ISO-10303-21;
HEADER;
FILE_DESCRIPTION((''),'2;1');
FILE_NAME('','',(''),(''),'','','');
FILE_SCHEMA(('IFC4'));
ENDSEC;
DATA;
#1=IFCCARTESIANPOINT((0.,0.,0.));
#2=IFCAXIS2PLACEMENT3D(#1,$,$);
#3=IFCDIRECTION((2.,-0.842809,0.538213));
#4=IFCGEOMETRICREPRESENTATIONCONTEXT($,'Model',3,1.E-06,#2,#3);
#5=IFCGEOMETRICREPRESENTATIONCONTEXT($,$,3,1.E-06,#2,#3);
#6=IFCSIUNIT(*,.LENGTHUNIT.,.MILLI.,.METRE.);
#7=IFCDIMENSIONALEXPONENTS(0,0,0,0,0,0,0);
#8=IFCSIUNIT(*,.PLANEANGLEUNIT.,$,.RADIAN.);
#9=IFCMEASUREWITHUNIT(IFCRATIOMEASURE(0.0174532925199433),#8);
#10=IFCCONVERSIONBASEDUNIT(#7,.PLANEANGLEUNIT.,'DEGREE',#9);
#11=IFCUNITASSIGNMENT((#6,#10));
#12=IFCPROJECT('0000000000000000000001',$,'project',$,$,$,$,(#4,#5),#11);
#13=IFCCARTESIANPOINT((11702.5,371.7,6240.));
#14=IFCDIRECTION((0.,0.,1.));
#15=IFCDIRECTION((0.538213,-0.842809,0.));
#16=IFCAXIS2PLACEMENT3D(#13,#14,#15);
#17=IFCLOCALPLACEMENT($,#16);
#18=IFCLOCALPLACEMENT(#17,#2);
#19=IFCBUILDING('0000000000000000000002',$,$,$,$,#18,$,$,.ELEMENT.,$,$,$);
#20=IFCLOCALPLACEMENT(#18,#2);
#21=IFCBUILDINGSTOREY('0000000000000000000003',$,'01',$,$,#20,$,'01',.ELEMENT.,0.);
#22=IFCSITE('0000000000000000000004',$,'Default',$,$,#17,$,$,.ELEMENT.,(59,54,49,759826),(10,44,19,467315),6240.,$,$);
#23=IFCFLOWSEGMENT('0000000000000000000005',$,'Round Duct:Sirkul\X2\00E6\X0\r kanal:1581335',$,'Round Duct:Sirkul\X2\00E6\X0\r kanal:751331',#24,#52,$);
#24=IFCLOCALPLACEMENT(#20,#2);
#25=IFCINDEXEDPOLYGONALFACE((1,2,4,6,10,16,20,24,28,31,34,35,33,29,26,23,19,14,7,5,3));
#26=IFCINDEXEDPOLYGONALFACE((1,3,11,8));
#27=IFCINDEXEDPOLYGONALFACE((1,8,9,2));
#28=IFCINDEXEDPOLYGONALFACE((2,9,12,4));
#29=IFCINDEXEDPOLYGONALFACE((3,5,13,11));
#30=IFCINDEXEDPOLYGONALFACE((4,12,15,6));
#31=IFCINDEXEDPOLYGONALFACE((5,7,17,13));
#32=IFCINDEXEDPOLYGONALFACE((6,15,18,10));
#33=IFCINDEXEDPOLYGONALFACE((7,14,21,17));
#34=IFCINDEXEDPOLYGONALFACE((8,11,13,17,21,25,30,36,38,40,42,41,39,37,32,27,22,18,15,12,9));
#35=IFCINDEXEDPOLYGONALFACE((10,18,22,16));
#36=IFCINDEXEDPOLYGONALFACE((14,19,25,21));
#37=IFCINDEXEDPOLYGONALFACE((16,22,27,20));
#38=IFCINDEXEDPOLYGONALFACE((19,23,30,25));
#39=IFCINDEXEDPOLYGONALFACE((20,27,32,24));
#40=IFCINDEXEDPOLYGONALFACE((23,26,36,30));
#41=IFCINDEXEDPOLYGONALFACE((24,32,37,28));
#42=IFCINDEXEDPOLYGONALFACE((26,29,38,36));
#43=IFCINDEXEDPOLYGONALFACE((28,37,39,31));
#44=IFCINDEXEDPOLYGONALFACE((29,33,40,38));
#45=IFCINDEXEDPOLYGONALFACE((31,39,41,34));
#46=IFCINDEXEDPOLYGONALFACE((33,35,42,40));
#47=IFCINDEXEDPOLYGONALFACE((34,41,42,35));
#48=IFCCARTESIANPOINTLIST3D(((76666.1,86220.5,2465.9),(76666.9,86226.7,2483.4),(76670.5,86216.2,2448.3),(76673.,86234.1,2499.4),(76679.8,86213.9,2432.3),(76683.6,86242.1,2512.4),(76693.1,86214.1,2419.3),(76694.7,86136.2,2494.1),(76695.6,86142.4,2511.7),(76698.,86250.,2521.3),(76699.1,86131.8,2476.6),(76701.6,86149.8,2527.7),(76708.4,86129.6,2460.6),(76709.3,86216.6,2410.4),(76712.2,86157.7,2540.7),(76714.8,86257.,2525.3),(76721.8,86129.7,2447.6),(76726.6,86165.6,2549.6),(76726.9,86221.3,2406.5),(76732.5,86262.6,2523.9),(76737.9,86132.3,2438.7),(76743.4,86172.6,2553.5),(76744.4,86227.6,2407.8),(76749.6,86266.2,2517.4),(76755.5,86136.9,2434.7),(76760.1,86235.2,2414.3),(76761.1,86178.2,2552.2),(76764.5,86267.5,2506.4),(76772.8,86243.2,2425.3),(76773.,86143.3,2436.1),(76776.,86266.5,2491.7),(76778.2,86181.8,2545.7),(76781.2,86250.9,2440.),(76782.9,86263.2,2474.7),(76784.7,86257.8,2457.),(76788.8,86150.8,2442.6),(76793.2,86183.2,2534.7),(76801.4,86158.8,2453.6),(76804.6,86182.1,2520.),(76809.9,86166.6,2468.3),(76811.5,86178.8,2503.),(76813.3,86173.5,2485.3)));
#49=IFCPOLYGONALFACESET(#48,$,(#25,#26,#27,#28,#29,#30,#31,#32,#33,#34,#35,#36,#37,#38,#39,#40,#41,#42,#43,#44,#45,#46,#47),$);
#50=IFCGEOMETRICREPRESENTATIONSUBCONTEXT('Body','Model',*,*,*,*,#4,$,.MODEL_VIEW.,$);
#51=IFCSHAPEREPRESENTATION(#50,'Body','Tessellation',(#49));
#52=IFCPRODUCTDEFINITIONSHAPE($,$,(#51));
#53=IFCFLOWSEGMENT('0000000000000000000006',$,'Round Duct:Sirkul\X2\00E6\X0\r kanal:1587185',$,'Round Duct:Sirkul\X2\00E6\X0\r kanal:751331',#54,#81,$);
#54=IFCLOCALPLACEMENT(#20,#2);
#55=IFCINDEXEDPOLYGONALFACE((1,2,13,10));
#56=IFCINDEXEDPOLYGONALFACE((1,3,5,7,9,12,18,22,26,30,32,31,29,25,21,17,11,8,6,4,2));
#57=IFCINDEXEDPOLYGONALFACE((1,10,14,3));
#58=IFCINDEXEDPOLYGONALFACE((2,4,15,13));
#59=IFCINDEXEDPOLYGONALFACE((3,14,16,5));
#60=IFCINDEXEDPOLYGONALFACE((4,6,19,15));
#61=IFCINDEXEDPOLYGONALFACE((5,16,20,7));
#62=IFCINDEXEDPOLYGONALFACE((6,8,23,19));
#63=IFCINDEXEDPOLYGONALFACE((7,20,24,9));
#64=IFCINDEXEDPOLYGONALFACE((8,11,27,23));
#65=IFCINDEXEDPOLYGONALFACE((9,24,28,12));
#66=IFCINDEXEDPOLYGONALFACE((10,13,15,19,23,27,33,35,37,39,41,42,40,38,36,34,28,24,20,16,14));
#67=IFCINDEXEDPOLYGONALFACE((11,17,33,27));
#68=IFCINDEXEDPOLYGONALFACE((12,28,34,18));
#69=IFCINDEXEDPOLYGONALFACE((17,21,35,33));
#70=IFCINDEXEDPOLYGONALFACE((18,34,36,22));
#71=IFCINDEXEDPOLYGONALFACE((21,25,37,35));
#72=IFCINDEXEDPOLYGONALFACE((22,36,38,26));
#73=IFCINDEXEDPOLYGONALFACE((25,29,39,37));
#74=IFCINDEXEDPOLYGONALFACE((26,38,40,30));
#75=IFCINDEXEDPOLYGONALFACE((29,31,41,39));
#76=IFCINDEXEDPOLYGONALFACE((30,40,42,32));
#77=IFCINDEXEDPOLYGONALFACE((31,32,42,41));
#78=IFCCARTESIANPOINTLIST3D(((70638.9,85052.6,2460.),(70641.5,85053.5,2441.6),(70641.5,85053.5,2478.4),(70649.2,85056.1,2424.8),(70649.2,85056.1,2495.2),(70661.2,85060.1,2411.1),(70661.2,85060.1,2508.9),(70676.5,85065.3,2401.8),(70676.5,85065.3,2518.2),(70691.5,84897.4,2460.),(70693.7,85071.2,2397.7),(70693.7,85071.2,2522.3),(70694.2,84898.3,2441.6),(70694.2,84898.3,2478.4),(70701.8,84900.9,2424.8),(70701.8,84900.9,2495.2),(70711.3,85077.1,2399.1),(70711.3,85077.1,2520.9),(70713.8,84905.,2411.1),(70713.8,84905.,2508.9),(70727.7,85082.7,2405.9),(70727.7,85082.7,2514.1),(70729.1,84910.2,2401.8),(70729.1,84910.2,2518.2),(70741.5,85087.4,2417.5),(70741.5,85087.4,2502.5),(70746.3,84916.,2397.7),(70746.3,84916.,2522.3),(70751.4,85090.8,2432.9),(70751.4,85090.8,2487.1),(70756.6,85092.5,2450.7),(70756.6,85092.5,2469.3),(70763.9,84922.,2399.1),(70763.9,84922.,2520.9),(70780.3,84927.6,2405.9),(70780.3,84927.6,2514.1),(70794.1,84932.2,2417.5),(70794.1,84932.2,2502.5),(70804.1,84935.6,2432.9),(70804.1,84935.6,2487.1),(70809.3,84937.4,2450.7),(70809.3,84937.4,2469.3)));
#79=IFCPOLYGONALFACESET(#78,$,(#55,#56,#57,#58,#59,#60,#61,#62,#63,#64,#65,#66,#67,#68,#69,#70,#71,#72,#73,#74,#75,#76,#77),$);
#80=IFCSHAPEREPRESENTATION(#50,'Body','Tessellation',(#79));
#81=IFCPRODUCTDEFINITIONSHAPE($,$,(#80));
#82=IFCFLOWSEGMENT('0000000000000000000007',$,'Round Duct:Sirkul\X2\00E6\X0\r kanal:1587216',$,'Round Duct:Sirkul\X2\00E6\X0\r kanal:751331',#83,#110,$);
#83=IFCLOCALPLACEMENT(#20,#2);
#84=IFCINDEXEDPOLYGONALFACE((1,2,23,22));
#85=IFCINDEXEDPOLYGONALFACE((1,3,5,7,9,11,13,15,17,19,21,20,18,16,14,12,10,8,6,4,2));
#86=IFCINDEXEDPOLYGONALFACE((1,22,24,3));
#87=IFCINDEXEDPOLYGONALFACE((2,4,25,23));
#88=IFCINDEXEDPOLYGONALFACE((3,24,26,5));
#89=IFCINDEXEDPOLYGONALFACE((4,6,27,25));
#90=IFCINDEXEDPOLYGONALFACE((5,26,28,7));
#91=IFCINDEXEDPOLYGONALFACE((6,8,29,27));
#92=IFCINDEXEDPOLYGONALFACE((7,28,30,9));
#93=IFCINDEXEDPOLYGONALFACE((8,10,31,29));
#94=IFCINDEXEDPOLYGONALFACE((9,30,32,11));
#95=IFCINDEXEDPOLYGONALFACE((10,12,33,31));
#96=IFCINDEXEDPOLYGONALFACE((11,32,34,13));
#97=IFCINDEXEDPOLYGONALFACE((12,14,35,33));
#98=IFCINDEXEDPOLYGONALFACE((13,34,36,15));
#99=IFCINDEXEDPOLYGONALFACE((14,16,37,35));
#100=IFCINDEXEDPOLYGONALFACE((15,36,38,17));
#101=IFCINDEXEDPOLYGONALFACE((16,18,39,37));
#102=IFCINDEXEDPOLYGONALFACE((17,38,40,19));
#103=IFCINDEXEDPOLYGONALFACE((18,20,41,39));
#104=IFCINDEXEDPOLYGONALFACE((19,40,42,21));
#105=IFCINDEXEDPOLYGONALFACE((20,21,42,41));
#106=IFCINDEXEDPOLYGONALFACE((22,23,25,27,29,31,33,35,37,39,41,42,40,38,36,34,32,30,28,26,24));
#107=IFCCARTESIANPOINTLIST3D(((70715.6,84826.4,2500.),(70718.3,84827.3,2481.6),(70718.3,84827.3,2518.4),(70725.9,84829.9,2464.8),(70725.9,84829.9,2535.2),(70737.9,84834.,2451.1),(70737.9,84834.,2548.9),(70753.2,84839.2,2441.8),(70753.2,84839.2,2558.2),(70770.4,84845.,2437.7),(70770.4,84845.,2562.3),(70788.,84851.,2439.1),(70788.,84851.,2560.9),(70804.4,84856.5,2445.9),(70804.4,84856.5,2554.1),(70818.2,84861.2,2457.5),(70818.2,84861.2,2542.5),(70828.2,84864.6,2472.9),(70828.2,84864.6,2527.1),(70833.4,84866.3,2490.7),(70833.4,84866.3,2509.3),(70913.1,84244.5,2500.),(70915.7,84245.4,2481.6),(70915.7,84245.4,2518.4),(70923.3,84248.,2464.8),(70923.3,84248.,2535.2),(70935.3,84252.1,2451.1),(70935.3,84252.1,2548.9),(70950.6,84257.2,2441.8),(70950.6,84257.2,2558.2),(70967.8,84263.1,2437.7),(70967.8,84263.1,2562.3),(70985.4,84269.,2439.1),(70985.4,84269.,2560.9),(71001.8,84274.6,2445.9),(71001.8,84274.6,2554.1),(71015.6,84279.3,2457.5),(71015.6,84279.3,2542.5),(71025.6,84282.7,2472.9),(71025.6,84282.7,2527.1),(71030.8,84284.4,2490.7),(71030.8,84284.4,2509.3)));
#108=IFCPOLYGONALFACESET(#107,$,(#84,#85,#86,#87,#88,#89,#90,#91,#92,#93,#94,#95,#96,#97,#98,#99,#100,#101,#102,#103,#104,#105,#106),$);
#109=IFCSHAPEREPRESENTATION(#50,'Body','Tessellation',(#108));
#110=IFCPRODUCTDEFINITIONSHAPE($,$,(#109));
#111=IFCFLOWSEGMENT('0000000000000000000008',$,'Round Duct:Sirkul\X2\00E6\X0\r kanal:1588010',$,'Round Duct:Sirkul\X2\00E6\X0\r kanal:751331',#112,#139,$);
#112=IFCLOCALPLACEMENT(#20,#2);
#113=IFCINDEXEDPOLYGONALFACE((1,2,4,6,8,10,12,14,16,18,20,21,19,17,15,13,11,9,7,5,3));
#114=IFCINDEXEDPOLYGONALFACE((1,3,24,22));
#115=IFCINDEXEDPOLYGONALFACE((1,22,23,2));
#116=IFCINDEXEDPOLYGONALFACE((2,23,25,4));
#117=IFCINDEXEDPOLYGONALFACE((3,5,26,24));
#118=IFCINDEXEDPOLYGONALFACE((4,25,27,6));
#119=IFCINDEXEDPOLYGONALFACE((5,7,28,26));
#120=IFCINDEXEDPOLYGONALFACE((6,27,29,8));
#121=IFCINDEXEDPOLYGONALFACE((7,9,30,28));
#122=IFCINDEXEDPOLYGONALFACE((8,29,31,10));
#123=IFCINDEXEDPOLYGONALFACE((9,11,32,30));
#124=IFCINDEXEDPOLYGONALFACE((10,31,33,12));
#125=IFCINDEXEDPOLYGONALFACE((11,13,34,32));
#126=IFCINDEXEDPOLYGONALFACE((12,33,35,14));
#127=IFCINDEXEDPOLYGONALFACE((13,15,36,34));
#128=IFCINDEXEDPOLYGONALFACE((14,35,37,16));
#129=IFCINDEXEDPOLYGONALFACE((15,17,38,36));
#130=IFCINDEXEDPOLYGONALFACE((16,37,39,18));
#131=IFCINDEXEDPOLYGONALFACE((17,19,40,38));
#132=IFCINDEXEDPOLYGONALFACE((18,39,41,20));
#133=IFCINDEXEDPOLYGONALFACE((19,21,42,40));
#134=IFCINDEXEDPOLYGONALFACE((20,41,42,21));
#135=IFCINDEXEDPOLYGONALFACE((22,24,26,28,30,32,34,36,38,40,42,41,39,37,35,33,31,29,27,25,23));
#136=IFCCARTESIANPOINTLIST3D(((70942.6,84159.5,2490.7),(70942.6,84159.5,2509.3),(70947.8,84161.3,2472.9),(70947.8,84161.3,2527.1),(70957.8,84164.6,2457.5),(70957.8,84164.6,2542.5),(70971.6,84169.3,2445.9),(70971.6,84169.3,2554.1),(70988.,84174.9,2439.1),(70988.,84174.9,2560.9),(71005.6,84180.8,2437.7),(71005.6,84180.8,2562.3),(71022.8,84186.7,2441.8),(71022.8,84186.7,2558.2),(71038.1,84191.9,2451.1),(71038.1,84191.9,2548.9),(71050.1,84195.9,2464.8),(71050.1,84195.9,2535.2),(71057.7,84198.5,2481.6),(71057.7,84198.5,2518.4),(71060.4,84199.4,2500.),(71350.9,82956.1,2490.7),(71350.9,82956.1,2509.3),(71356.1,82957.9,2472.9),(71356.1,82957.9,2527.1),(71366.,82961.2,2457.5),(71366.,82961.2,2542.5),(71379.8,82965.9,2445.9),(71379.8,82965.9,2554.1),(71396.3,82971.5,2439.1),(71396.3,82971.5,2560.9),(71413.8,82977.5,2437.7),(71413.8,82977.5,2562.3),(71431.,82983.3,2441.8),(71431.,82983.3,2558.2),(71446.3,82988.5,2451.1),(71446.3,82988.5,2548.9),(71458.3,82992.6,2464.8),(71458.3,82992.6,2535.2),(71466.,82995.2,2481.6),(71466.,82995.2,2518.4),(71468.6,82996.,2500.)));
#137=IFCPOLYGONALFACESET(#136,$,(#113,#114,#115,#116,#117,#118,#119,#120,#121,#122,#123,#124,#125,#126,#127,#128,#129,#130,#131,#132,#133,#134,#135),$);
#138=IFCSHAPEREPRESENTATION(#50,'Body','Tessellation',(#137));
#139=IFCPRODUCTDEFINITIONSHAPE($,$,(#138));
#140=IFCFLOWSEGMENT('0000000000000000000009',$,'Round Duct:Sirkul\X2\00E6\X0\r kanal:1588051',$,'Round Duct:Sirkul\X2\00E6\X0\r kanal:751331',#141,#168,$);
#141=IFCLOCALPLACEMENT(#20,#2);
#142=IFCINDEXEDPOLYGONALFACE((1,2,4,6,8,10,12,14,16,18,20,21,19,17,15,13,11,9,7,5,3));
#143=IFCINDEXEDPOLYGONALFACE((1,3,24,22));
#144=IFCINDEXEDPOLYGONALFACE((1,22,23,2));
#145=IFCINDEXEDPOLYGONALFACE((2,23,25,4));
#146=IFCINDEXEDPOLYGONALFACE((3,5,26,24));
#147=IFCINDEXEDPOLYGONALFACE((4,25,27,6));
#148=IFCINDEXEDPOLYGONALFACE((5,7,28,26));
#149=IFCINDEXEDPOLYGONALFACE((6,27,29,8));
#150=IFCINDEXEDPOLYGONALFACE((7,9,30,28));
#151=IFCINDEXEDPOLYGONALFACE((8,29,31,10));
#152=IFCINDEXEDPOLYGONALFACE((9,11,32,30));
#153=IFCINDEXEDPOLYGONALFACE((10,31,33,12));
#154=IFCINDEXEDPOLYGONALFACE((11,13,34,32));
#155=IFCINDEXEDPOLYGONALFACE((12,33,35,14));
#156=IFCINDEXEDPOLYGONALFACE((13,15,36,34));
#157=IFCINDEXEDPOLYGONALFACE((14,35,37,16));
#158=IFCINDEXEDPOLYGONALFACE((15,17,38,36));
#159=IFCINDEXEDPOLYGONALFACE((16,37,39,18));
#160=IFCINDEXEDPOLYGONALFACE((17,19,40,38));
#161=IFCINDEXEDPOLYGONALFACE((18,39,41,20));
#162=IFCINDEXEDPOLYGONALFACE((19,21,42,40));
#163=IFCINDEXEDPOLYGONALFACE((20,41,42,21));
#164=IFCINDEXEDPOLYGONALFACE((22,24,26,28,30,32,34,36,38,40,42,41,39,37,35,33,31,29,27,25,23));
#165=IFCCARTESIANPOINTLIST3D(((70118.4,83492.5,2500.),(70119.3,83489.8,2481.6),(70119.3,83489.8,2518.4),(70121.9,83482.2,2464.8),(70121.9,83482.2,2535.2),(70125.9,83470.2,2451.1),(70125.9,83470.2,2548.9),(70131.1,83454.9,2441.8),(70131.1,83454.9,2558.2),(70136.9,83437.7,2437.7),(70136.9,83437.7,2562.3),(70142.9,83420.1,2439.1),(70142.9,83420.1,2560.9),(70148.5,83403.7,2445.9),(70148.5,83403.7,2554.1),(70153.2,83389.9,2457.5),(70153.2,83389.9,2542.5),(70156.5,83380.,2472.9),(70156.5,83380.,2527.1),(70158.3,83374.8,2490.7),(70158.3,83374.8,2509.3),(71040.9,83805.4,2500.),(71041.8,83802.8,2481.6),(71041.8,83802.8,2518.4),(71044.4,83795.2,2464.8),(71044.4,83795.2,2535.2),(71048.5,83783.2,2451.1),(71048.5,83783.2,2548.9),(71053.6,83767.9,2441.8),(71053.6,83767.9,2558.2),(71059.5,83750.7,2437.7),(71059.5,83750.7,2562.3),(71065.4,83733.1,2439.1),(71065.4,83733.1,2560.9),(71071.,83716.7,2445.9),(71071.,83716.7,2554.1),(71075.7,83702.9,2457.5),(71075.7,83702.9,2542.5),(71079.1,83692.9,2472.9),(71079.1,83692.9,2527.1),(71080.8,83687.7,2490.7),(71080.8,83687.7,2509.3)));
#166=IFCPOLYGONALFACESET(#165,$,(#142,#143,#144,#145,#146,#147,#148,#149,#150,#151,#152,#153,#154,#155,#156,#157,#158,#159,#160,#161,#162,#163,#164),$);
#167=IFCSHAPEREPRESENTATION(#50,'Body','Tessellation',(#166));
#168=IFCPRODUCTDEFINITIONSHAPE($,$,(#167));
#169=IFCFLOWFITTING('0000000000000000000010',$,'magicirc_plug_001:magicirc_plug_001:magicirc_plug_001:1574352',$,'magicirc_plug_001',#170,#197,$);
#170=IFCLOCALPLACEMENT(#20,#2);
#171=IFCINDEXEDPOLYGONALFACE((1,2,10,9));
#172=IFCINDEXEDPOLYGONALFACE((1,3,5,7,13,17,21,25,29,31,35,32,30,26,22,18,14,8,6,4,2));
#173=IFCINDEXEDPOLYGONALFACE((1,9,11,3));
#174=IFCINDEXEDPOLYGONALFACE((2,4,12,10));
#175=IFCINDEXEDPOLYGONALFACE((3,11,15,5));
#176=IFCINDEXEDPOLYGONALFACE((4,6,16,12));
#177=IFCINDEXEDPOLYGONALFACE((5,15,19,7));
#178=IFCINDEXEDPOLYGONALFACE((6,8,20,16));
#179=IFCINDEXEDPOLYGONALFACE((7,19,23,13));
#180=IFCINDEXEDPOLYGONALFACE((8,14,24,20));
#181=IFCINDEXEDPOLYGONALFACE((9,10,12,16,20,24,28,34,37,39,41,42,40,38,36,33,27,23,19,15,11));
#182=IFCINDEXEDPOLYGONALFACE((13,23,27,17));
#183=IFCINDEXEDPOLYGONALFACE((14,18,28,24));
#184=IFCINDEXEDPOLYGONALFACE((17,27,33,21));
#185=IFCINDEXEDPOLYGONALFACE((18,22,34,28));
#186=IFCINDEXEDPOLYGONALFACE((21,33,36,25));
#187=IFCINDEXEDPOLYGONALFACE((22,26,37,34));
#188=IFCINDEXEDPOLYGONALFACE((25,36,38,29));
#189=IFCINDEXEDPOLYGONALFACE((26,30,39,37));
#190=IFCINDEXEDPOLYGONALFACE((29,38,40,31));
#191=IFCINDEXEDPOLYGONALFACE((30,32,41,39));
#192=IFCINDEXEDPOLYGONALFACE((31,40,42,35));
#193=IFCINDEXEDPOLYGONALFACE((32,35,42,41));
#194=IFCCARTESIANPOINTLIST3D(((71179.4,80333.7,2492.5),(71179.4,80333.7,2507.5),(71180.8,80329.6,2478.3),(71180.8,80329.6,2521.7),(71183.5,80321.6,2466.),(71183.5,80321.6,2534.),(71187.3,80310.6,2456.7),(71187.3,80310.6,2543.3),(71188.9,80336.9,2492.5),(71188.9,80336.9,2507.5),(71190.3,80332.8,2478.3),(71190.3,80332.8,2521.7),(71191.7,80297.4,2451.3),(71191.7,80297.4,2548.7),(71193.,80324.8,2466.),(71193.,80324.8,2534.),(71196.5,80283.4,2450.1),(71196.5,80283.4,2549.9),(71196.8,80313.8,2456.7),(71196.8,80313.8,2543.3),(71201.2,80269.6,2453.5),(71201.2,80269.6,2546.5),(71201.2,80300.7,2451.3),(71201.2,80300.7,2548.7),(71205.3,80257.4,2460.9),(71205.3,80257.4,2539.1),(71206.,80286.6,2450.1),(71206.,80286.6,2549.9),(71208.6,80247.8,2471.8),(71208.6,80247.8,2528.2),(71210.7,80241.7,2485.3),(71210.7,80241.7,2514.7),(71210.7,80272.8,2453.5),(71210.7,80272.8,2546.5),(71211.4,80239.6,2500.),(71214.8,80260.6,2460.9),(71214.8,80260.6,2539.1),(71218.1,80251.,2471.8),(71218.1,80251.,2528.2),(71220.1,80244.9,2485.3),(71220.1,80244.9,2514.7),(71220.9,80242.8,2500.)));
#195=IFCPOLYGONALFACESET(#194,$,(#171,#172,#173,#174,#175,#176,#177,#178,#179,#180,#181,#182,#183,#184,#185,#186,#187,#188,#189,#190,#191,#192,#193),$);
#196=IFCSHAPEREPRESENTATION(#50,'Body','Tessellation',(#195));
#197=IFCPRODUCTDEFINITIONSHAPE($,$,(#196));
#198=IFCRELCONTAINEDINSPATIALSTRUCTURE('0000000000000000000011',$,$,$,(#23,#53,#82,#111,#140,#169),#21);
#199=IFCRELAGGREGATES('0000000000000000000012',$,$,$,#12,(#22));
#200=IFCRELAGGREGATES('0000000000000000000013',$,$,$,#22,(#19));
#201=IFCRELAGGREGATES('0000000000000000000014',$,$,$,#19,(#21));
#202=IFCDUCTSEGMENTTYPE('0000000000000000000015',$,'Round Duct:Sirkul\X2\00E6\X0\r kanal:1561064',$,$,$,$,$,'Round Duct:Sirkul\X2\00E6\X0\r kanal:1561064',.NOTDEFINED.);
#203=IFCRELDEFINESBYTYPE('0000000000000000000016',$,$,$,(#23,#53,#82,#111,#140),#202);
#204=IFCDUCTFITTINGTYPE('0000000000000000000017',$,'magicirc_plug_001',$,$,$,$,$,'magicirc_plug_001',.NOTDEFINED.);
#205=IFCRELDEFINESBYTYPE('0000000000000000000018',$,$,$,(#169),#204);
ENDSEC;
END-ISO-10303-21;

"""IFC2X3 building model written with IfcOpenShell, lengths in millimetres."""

from ifc_helpers import new_model, entity, si_unit, converted_unit, direction, frame, frame_2d, origin, origin_2d_with_axis, place, context, subcontext, project, spatial, circle, extrude, source, transform, mapped, type_object, type_shapes, element, save


model = new_model("IFC2X3")

# Units and contexts
model_context = context("Model", 3, precision=1e-06, world=origin(), true_north=direction((2.0, -0.842809, 0.538213)))
context_of_model = context(None, 3, precision=1e-06, world=origin(), true_north=direction((2.0, -0.842809, 0.538213)))
body_context = subcontext(model_context, "Body", "Model", "MODEL_VIEW")
ifc_project = project(units=[si_unit("LENGTHUNIT", "METRE", prefix="MILLI"), converted_unit("PLANEANGLEUNIT", "DEGREE", entity("IfcRatioMeasure", 0.0174532925199433), si_unit("PLANEANGLEUNIT", "RADIAN"), dimensions=[0, 0, 0, 0, 0, 0, 0])], contexts=[model_context, context_of_model])

# Site, building, storey
site_placement = place(None, frame((11702.5, 371.7, 6240.0), z_axis=(0.0, 0.0, 1.0), x_axis=(0.538213, -0.842809, 0.0)))
site = spatial("IfcSite", under=ifc_project, at=site_placement, Name="Default", CompositionType="ELEMENT", RefLatitude=(59, 54, 49, 759826), RefLongitude=(10, 44, 19, 467315), RefElevation=6240.0)
building_placement = place(site_placement, origin())
building = spatial("IfcBuilding", under=site, at=building_placement, CompositionType="ELEMENT")
storey_placement = place(building_placement, origin())
storey = spatial("IfcBuildingStorey", under=building, at=storey_placement, Name="01", LongName="01", CompositionType="ELEMENT", Elevation=0.0)

# Flow segments
duct_segment_type = type_object("IfcDuctSegmentType", Name="Round Duct:Sirkulær kanal:1561064", ElementType="Round Duct:Sirkulær kanal:1561064", PredefinedType="NOTDEFINED")
flow_segment_1_placement = place(storey_placement, origin())
element("IfcFlowSegment", 1, at=flow_segment_1_placement, inside=storey, type_object=duct_segment_type, Name="Round Duct:Sirkulær kanal:1581335", ObjectType="Round Duct:Sirkulær kanal:751331", context=body_context, shape_type="SweptSolid", body=[
    extrude(circle(Radius=62.5, at=frame_2d((0.0, 0.0), x_axis=(1.0, 0.0))), frame((76725.3, 86240.6, 2465.9), z_axis=(0.306214, -0.902596, 0.302579), x_axis=(-0.946986, -0.321274, 0.0)), (0.0, 0.0, 1.0), 93.5),
])
flow_segment_2_placement = place(storey_placement, origin())
element("IfcFlowSegment", 2, at=flow_segment_2_placement, inside=storey, type_object=duct_segment_type, Name="Round Duct:Sirkulær kanal:1587185", ObjectType="Round Duct:Sirkulær kanal:751331", context=body_context, shape_type="SweptSolid", body=[
    extrude(circle(Radius=62.5, at=origin_2d_with_axis()), frame((70698.1, 85072.7, 2460.0), z_axis=(0.321315, -0.946972, 0.0), x_axis=(-0.946972, -0.321315, 0.0)), (0.0, 0.0, 1.0), 163.8),
])
flow_segment_3_placement = place(storey_placement, origin())
element("IfcFlowSegment", 3, at=flow_segment_3_placement, inside=storey, type_object=duct_segment_type, Name="Round Duct:Sirkulær kanal:1587216", ObjectType="Round Duct:Sirkulær kanal:751331", context=body_context, shape_type="SweptSolid", body=[
    extrude(circle(Radius=62.5, at=origin_2d_with_axis()), frame((70774.8, 84846.5, 2500.0), z_axis=(0.321274, -0.946986, 0.0), x_axis=(-0.946986, -0.321274, 0.0)), (0.0, 0.0, 1.0), 614.5),
])
flow_segment_4_placement = place(storey_placement, origin())
element("IfcFlowSegment", 4, at=flow_segment_4_placement, inside=storey, type_object=duct_segment_type, Name="Round Duct:Sirkulær kanal:1588010", ObjectType="Round Duct:Sirkulær kanal:751331", context=body_context, shape_type="SweptSolid", body=[
    extrude(circle(Radius=62.5, at=origin_2d_with_axis()), frame((71409.4, 82976.0, 2500.0), z_axis=(-0.321274, 0.946986, 0.0), x_axis=(0.946986, 0.321274, 0.0)), (0.0, 0.0, 1.0), 1270.7),
])
flow_segment_5_placement = place(storey_placement, origin())
element("IfcFlowSegment", 5, at=flow_segment_5_placement, inside=storey, type_object=duct_segment_type, Name="Round Duct:Sirkulær kanal:1588051", ObjectType="Round Duct:Sirkulær kanal:751331", context=body_context, shape_type="SweptSolid", body=[
    extrude(circle(Radius=62.5, at=frame_2d((0.0, 0.0), x_axis=(1.0, 0.0))), frame((70138.4, 83433.3, 2500.0), z_axis=(0.946986, 0.321274, 0.0), x_axis=(-0.321274, 0.946986, 0.0)), (0.0, 0.0, 1.0), 974.2),
])

# Flow fitting
duct_fitting_type_1 = type_object("IfcDuctFittingType", Name="magicirc_plug_001", ElementType="magicirc_plug_001", PredefinedType="NOTDEFINED")
shared_shape_1 = source(origin(), body_context, "Body", "SweptSolid", [
    extrude(circle(Radius=50.0, at=frame_2d((0.0, 0.0), x_axis=(1.0, 0.0))), frame((0.0, 0.0, 0.0), z_axis=(1.0, 0.0, 0.0), x_axis=(0.0, 1.0, 0.0)), (0.0, 0.0, 1.0), 10.0),
])
type_shapes(duct_fitting_type_1, [shared_shape_1])
flow_fitting_placement = place(storey_placement, frame((71204.8, 80290.1, 2500.0), z_axis=(0.0, 0.0, 1.0), x_axis=(-0.946986, -0.321274, 0.0)))
element("IfcFlowFitting", 6, at=flow_fitting_placement, inside=storey, type_object=duct_fitting_type_1, Name="magicirc_plug_001:magicirc_plug_001:magicirc_plug_001:1574352", ObjectType="magicirc_plug_001", context=body_context, shape_type="MappedRepresentation", body=[
    mapped(shared_shape_1, transform((0.0, 0.0, 0.0), scale=1.0)),
])

save(model, "model.ifc")
